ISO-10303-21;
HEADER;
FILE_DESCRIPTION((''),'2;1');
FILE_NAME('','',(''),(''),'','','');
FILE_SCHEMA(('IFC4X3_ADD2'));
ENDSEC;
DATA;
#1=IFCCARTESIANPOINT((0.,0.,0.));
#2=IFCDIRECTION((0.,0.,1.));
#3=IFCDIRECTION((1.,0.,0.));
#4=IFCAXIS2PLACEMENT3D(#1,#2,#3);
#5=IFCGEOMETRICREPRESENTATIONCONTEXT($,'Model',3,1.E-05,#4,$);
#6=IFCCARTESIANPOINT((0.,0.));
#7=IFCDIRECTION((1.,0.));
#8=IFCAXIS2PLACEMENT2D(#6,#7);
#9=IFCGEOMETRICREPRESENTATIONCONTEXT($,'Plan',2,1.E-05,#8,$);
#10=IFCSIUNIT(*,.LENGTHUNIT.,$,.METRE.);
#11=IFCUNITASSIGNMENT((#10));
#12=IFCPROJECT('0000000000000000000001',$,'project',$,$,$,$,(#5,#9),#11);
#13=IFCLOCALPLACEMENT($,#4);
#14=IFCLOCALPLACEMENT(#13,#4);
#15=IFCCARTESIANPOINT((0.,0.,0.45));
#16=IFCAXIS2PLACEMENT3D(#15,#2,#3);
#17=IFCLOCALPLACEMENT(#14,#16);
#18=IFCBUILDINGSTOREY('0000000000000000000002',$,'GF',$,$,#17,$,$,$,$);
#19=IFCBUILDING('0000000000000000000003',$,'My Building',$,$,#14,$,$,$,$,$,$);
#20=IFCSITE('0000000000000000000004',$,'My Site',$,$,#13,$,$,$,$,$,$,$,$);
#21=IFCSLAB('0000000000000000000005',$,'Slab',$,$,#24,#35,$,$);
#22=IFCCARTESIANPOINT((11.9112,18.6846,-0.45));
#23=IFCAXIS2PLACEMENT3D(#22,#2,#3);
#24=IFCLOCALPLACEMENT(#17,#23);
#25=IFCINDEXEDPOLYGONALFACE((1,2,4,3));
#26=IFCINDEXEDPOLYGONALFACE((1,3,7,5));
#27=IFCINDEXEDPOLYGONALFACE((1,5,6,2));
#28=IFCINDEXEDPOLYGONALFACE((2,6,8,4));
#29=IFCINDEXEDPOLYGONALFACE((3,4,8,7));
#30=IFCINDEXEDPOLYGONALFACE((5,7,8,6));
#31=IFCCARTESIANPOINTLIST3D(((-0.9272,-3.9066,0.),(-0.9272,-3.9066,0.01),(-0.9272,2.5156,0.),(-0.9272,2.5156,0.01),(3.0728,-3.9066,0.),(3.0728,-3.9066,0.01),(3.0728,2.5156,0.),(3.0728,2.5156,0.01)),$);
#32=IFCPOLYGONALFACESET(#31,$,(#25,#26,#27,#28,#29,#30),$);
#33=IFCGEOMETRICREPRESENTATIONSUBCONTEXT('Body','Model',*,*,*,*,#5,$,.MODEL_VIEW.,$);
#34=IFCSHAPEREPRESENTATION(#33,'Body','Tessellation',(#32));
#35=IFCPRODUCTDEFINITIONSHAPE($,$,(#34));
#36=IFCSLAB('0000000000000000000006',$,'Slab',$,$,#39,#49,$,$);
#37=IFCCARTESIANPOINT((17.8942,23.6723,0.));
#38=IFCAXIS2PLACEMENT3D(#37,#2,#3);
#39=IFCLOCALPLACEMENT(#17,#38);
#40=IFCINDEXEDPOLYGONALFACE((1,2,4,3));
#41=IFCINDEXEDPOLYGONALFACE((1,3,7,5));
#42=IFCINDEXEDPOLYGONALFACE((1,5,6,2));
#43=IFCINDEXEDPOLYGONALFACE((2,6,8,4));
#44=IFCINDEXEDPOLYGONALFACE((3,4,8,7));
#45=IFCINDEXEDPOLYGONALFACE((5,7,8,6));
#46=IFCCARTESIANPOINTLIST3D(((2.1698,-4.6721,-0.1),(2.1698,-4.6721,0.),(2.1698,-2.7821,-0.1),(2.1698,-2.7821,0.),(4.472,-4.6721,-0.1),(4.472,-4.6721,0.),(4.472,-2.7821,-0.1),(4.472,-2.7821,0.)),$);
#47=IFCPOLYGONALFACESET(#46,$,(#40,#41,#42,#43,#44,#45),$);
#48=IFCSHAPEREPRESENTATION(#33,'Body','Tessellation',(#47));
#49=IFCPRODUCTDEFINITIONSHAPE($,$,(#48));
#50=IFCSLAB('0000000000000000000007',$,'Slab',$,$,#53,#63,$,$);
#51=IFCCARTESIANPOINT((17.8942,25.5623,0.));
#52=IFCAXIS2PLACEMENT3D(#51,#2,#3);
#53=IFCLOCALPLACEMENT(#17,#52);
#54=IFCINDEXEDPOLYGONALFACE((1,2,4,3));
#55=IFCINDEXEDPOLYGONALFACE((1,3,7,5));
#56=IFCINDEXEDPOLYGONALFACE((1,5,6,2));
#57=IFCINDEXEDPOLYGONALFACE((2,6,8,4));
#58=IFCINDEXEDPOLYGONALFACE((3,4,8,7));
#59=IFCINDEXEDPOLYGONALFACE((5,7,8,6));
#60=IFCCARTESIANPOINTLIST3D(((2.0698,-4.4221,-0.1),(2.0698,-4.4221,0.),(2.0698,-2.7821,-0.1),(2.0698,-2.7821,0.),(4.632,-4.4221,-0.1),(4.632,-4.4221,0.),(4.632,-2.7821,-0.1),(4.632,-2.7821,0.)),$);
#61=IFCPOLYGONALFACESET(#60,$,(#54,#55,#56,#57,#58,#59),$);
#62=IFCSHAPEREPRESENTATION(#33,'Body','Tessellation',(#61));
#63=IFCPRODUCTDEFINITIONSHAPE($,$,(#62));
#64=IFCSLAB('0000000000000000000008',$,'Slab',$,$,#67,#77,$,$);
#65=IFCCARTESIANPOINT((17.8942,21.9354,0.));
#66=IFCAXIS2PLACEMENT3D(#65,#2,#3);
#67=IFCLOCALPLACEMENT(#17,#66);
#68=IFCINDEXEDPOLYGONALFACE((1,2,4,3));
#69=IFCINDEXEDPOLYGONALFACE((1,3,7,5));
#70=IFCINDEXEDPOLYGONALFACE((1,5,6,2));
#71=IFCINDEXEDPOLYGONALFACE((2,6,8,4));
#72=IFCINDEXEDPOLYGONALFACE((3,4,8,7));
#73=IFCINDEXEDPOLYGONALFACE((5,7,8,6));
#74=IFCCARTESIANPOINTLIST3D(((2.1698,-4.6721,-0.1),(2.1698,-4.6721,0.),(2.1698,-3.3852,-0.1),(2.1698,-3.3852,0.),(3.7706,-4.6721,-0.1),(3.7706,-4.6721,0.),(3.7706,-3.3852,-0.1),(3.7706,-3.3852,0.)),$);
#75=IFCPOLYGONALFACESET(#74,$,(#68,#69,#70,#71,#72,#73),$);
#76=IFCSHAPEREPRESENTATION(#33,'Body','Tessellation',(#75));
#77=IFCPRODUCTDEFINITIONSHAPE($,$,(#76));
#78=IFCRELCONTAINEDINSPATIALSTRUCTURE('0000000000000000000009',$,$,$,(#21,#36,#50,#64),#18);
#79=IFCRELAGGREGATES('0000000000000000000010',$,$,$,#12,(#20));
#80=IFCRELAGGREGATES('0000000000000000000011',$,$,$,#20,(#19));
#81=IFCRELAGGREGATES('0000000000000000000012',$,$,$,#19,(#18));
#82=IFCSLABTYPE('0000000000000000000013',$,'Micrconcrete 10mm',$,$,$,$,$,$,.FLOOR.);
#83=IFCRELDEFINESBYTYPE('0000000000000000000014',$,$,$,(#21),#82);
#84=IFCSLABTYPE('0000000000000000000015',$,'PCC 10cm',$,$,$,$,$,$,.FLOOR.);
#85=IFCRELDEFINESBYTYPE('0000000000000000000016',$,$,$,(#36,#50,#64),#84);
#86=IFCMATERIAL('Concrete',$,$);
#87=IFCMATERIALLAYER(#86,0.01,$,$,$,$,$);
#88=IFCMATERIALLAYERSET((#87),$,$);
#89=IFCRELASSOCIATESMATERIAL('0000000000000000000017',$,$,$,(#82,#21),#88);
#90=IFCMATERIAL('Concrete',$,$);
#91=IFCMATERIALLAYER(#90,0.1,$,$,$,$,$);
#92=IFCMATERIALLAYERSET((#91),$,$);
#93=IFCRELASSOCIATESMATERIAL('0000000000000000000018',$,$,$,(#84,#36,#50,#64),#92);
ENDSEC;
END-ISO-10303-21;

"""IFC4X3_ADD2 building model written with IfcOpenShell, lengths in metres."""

from ifc_helpers import new_model, si_unit, frame, origin_with_axes, origin_2d_with_axis, place, context, subcontext, project, spatial, line, indexed_curve, outline, extrude, material, layer, layer_set, layer_usage, type_object, element, save


model = new_model("IFC4X3_ADD2")

# Units and contexts
model_context = context("Model", 3, precision=1e-05, world=origin_with_axes())
plan_context = context("Plan", 2, precision=1e-05, world=origin_2d_with_axis())
body_context_1 = subcontext(model_context, "Body", "Model", "MODEL_VIEW")
ifc_project = project(units=[si_unit("LENGTHUNIT", "METRE")], contexts=[model_context, plan_context])

# Site, building, storey
site_placement = place(None, origin_with_axes())
site = spatial("IfcSite", under=ifc_project, at=site_placement, Name="My Site")
building_placement = place(site_placement, origin_with_axes())
building = spatial("IfcBuilding", under=site, at=building_placement, Name="My Building")
storey_placement = place(building_placement, frame((0.0, 0.0, 0.45), z_axis=(0.0, 0.0, 1.0), x_axis=(1.0, 0.0, 0.0)))
storey = spatial("IfcBuildingStorey", under=building, at=storey_placement, Name="GF")

# Slabs
ifc_material_1 = material(Name="Concrete")
ifc_layer_1 = layer(ifc_material_1, 0.01)
ifc_layer_set_1 = layer_set([ifc_layer_1])
ifc_layer_usage_1 = layer_usage(ifc_layer_set_1, "AXIS3", "POSITIVE", 0.0)
slab_type_1 = type_object("IfcSlabType", Name="Micrconcrete 10mm", PredefinedType="FLOOR", material=ifc_layer_set_1)
slab_1_placement = place(storey_placement, frame((11.9112, 18.6846, -0.45), z_axis=(0.0, 0.0, 1.0), x_axis=(1.0, 0.0, 0.0)))
element("IfcSlab", 1, at=slab_1_placement, inside=storey, type_object=slab_type_1, material=ifc_layer_usage_1, Name="Slab", context=body_context_1, shape_type="SweptSolid", body=[
    extrude(outline(indexed_curve([(3.0728, 2.5156), (3.0728, -3.9066), (-0.9272, -3.9066), (-0.9272, 2.5156)], segments=[line(3, 2), line(2, 1), line(1, 4), line(4, 3)], self_intersect=False)), None, (0.0, 0.0, 1.0), 0.01),
])
ifc_material_2 = material(Name="Concrete")
ifc_layer_2 = layer(ifc_material_2, 0.1)
ifc_layer_set_2 = layer_set([ifc_layer_2])
slab_type_2 = type_object("IfcSlabType", Name="PCC 10cm", PredefinedType="FLOOR", material=ifc_layer_set_2)
ifc_layer_usage_2 = layer_usage(ifc_layer_set_2, "AXIS3", "POSITIVE", -0.1)
slab_2_placement = place(storey_placement, frame((17.8942, 23.6723, 0.0), z_axis=(0.0, 0.0, 1.0), x_axis=(1.0, 0.0, 0.0)))
element("IfcSlab", 2, at=slab_2_placement, inside=storey, type_object=slab_type_2, material=ifc_layer_usage_2, Name="Slab", context=body_context_1, shape_type="SweptSolid", body=[
    extrude(outline(indexed_curve([(2.1698, -4.6721), (4.472, -4.6721), (4.472, -2.7821), (2.1698, -2.7821), (2.1698, -4.6721)])), frame((0.0, 0.0, -0.1), z_axis=(0.0, 0.0, 1.0), x_axis=(1.0, 0.0, 0.0)), (0.0, 0.0, 1.0), 0.1),
])
ifc_layer_usage_3 = layer_usage(ifc_layer_set_2, "AXIS3", "POSITIVE", -0.1)
slab_3_placement = place(storey_placement, frame((17.8942, 25.5623, 0.0), z_axis=(0.0, 0.0, 1.0), x_axis=(1.0, 0.0, 0.0)))
element("IfcSlab", 3, at=slab_3_placement, inside=storey, type_object=slab_type_2, material=ifc_layer_usage_3, Name="Slab", context=body_context_1, shape_type="SweptSolid", body=[
    extrude(outline(indexed_curve([(2.0698, -2.7821), (4.632, -2.7821), (4.632, -4.4221), (2.0698, -4.4221), (2.0698, -2.7821)])), frame((0.0, 0.0, -0.1), z_axis=(0.0, 0.0, 1.0), x_axis=(1.0, 0.0, 0.0)), (0.0, 0.0, 1.0), 0.1),
])
ifc_layer_usage_4 = layer_usage(ifc_layer_set_2, "AXIS3", "POSITIVE", -0.1)
slab_4_placement = place(storey_placement, frame((17.8942, 21.9354, 0.0), z_axis=(0.0, 0.0, 1.0), x_axis=(1.0, 0.0, 0.0)))
element("IfcSlab", 4, at=slab_4_placement, inside=storey, type_object=slab_type_2, material=ifc_layer_usage_4, Name="Slab", context=body_context_1, shape_type="SweptSolid", body=[
    extrude(outline(indexed_curve([(2.1698, -3.3852), (3.7706, -3.3852), (3.7706, -4.6721), (2.1698, -4.6721), (2.1698, -3.3852)])), frame((0.0, 0.0, -0.1), z_axis=(0.0, 0.0, 1.0), x_axis=(1.0, 0.0, 0.0)), (0.0, 0.0, 1.0), 0.1),
])

save(model, "model.ifc")
